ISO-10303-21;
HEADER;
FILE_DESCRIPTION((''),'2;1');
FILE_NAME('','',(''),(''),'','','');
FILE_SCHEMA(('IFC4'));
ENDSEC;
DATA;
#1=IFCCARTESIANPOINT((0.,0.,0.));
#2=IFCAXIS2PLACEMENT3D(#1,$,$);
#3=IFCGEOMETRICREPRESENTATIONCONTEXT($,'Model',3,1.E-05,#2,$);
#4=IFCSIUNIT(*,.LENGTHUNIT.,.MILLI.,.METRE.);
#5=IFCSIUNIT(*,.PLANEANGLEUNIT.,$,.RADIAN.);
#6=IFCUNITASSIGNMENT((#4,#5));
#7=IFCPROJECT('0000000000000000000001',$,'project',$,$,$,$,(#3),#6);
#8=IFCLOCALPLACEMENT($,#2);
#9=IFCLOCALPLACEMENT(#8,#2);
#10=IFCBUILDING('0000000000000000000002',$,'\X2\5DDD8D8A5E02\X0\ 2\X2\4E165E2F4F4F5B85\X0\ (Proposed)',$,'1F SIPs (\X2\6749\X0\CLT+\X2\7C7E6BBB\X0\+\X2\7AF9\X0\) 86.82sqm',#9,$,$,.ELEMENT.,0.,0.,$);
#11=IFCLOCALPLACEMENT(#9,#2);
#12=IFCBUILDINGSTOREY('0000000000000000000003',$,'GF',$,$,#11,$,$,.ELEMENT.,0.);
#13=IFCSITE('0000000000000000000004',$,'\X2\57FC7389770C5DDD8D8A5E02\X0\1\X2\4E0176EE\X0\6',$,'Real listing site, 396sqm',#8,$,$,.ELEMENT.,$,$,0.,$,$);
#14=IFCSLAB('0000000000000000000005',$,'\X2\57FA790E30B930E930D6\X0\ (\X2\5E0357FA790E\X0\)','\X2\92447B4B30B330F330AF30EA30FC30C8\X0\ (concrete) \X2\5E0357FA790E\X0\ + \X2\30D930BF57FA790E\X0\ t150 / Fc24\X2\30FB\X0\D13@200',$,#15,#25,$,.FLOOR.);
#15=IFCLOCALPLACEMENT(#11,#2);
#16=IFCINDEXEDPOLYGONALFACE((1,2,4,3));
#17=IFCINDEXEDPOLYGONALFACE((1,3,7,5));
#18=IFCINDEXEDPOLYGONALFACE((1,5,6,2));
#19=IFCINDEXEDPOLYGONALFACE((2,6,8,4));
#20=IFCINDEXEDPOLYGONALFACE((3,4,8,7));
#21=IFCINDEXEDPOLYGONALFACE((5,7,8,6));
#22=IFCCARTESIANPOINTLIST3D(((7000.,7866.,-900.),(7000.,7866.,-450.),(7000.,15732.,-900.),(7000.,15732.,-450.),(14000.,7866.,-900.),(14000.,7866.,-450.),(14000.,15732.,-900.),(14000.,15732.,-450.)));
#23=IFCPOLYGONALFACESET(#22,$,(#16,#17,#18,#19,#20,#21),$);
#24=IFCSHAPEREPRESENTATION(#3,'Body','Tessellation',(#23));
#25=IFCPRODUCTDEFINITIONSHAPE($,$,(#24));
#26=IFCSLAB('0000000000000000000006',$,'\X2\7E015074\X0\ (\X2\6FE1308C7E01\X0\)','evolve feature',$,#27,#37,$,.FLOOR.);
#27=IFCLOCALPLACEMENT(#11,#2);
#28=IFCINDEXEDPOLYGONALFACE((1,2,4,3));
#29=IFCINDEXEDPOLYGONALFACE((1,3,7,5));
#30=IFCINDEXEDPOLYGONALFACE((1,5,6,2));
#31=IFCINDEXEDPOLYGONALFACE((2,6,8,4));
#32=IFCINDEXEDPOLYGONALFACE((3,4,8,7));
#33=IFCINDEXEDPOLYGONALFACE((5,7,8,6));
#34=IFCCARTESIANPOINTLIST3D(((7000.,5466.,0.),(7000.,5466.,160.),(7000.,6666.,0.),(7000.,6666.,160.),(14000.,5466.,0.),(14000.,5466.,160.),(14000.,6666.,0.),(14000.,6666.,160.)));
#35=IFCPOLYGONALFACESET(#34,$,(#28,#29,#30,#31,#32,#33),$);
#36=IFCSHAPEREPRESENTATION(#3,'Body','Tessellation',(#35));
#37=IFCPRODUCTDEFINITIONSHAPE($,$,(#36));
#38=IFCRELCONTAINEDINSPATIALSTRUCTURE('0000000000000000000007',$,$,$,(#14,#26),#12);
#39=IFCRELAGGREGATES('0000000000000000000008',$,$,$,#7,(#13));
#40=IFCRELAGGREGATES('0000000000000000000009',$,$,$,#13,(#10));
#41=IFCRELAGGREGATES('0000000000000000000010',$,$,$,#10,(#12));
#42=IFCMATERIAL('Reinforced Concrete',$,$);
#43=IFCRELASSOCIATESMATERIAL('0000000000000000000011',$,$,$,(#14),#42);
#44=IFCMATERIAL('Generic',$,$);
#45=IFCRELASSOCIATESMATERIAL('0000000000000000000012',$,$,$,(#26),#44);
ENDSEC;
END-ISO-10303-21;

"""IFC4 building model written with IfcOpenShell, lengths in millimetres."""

from ifc_helpers import new_model, si_unit, frame, frame_2d, origin, place, context, project, spatial, rectangle, extrude, material, element, save


model = new_model("IFC4")

# Units and contexts
model_context = context("Model", 3, precision=1e-05, world=origin())
ifc_project = project(units=[si_unit("LENGTHUNIT", "METRE", prefix="MILLI"), si_unit("PLANEANGLEUNIT", "RADIAN")], contexts=[model_context])

# Site, building, storey
site_placement = place(None, origin())
site = spatial("IfcSite", under=ifc_project, at=site_placement, Name="埼玉県川越市1丁目6", ObjectType="Real listing site, 396sqm", CompositionType="ELEMENT", RefElevation=0.0)
building_placement = place(site_placement, origin())
building = spatial("IfcBuilding", under=site, at=building_placement, Name="川越市 2世帯住宅 (Proposed)", ObjectType="1F SIPs (杉CLT+籾殻+竹) 86.82sqm", CompositionType="ELEMENT", ElevationOfRefHeight=0.0, ElevationOfTerrain=0.0)
storey_placement = place(building_placement, origin())
storey = spatial("IfcBuildingStorey", under=building, at=storey_placement, Name="GF", CompositionType="ELEMENT", Elevation=0.0)

# Slabs
ifc_material_1 = material(Name="Reinforced Concrete")
slab_1_placement = place(storey_placement, frame((3500.0, 3933.0, -450.0)))
element("IfcSlab", 1, at=slab_1_placement, inside=storey, material=ifc_material_1, Name="基礎スラブ (布基礎)", Description="鉄筋コンクリート (concrete) 布基礎 + ベタ基礎 t150 / Fc24・D13@200", PredefinedType="FLOOR", context=model_context, shape_type="SweptSolid", body=[
    extrude(rectangle(XDim=7000.0, YDim=7866.0, at=frame_2d((3500.0, 3933.0))), frame((3500.0, 3933.0, -450.0)), (0.0, 0.0, 1.0), 450.0),
])
ifc_material_2 = material(Name="Generic")
slab_2_placement = place(storey_placement, frame((3500.0, 2733.0, 0.0)))
element("IfcSlab", 2, at=slab_2_placement, inside=storey, material=ifc_material_2, Name="縁側 (濡れ縁)", Description="evolve feature", PredefinedType="FLOOR", context=model_context, shape_type="SweptSolid", body=[
    extrude(rectangle(XDim=7000.0, YDim=1200.0, at=frame_2d((3500.0, 600.0))), frame((3500.0, 2733.0, 0.0)), (0.0, 0.0, 1.0), 160.0),
])

save(model, "model.ifc")
